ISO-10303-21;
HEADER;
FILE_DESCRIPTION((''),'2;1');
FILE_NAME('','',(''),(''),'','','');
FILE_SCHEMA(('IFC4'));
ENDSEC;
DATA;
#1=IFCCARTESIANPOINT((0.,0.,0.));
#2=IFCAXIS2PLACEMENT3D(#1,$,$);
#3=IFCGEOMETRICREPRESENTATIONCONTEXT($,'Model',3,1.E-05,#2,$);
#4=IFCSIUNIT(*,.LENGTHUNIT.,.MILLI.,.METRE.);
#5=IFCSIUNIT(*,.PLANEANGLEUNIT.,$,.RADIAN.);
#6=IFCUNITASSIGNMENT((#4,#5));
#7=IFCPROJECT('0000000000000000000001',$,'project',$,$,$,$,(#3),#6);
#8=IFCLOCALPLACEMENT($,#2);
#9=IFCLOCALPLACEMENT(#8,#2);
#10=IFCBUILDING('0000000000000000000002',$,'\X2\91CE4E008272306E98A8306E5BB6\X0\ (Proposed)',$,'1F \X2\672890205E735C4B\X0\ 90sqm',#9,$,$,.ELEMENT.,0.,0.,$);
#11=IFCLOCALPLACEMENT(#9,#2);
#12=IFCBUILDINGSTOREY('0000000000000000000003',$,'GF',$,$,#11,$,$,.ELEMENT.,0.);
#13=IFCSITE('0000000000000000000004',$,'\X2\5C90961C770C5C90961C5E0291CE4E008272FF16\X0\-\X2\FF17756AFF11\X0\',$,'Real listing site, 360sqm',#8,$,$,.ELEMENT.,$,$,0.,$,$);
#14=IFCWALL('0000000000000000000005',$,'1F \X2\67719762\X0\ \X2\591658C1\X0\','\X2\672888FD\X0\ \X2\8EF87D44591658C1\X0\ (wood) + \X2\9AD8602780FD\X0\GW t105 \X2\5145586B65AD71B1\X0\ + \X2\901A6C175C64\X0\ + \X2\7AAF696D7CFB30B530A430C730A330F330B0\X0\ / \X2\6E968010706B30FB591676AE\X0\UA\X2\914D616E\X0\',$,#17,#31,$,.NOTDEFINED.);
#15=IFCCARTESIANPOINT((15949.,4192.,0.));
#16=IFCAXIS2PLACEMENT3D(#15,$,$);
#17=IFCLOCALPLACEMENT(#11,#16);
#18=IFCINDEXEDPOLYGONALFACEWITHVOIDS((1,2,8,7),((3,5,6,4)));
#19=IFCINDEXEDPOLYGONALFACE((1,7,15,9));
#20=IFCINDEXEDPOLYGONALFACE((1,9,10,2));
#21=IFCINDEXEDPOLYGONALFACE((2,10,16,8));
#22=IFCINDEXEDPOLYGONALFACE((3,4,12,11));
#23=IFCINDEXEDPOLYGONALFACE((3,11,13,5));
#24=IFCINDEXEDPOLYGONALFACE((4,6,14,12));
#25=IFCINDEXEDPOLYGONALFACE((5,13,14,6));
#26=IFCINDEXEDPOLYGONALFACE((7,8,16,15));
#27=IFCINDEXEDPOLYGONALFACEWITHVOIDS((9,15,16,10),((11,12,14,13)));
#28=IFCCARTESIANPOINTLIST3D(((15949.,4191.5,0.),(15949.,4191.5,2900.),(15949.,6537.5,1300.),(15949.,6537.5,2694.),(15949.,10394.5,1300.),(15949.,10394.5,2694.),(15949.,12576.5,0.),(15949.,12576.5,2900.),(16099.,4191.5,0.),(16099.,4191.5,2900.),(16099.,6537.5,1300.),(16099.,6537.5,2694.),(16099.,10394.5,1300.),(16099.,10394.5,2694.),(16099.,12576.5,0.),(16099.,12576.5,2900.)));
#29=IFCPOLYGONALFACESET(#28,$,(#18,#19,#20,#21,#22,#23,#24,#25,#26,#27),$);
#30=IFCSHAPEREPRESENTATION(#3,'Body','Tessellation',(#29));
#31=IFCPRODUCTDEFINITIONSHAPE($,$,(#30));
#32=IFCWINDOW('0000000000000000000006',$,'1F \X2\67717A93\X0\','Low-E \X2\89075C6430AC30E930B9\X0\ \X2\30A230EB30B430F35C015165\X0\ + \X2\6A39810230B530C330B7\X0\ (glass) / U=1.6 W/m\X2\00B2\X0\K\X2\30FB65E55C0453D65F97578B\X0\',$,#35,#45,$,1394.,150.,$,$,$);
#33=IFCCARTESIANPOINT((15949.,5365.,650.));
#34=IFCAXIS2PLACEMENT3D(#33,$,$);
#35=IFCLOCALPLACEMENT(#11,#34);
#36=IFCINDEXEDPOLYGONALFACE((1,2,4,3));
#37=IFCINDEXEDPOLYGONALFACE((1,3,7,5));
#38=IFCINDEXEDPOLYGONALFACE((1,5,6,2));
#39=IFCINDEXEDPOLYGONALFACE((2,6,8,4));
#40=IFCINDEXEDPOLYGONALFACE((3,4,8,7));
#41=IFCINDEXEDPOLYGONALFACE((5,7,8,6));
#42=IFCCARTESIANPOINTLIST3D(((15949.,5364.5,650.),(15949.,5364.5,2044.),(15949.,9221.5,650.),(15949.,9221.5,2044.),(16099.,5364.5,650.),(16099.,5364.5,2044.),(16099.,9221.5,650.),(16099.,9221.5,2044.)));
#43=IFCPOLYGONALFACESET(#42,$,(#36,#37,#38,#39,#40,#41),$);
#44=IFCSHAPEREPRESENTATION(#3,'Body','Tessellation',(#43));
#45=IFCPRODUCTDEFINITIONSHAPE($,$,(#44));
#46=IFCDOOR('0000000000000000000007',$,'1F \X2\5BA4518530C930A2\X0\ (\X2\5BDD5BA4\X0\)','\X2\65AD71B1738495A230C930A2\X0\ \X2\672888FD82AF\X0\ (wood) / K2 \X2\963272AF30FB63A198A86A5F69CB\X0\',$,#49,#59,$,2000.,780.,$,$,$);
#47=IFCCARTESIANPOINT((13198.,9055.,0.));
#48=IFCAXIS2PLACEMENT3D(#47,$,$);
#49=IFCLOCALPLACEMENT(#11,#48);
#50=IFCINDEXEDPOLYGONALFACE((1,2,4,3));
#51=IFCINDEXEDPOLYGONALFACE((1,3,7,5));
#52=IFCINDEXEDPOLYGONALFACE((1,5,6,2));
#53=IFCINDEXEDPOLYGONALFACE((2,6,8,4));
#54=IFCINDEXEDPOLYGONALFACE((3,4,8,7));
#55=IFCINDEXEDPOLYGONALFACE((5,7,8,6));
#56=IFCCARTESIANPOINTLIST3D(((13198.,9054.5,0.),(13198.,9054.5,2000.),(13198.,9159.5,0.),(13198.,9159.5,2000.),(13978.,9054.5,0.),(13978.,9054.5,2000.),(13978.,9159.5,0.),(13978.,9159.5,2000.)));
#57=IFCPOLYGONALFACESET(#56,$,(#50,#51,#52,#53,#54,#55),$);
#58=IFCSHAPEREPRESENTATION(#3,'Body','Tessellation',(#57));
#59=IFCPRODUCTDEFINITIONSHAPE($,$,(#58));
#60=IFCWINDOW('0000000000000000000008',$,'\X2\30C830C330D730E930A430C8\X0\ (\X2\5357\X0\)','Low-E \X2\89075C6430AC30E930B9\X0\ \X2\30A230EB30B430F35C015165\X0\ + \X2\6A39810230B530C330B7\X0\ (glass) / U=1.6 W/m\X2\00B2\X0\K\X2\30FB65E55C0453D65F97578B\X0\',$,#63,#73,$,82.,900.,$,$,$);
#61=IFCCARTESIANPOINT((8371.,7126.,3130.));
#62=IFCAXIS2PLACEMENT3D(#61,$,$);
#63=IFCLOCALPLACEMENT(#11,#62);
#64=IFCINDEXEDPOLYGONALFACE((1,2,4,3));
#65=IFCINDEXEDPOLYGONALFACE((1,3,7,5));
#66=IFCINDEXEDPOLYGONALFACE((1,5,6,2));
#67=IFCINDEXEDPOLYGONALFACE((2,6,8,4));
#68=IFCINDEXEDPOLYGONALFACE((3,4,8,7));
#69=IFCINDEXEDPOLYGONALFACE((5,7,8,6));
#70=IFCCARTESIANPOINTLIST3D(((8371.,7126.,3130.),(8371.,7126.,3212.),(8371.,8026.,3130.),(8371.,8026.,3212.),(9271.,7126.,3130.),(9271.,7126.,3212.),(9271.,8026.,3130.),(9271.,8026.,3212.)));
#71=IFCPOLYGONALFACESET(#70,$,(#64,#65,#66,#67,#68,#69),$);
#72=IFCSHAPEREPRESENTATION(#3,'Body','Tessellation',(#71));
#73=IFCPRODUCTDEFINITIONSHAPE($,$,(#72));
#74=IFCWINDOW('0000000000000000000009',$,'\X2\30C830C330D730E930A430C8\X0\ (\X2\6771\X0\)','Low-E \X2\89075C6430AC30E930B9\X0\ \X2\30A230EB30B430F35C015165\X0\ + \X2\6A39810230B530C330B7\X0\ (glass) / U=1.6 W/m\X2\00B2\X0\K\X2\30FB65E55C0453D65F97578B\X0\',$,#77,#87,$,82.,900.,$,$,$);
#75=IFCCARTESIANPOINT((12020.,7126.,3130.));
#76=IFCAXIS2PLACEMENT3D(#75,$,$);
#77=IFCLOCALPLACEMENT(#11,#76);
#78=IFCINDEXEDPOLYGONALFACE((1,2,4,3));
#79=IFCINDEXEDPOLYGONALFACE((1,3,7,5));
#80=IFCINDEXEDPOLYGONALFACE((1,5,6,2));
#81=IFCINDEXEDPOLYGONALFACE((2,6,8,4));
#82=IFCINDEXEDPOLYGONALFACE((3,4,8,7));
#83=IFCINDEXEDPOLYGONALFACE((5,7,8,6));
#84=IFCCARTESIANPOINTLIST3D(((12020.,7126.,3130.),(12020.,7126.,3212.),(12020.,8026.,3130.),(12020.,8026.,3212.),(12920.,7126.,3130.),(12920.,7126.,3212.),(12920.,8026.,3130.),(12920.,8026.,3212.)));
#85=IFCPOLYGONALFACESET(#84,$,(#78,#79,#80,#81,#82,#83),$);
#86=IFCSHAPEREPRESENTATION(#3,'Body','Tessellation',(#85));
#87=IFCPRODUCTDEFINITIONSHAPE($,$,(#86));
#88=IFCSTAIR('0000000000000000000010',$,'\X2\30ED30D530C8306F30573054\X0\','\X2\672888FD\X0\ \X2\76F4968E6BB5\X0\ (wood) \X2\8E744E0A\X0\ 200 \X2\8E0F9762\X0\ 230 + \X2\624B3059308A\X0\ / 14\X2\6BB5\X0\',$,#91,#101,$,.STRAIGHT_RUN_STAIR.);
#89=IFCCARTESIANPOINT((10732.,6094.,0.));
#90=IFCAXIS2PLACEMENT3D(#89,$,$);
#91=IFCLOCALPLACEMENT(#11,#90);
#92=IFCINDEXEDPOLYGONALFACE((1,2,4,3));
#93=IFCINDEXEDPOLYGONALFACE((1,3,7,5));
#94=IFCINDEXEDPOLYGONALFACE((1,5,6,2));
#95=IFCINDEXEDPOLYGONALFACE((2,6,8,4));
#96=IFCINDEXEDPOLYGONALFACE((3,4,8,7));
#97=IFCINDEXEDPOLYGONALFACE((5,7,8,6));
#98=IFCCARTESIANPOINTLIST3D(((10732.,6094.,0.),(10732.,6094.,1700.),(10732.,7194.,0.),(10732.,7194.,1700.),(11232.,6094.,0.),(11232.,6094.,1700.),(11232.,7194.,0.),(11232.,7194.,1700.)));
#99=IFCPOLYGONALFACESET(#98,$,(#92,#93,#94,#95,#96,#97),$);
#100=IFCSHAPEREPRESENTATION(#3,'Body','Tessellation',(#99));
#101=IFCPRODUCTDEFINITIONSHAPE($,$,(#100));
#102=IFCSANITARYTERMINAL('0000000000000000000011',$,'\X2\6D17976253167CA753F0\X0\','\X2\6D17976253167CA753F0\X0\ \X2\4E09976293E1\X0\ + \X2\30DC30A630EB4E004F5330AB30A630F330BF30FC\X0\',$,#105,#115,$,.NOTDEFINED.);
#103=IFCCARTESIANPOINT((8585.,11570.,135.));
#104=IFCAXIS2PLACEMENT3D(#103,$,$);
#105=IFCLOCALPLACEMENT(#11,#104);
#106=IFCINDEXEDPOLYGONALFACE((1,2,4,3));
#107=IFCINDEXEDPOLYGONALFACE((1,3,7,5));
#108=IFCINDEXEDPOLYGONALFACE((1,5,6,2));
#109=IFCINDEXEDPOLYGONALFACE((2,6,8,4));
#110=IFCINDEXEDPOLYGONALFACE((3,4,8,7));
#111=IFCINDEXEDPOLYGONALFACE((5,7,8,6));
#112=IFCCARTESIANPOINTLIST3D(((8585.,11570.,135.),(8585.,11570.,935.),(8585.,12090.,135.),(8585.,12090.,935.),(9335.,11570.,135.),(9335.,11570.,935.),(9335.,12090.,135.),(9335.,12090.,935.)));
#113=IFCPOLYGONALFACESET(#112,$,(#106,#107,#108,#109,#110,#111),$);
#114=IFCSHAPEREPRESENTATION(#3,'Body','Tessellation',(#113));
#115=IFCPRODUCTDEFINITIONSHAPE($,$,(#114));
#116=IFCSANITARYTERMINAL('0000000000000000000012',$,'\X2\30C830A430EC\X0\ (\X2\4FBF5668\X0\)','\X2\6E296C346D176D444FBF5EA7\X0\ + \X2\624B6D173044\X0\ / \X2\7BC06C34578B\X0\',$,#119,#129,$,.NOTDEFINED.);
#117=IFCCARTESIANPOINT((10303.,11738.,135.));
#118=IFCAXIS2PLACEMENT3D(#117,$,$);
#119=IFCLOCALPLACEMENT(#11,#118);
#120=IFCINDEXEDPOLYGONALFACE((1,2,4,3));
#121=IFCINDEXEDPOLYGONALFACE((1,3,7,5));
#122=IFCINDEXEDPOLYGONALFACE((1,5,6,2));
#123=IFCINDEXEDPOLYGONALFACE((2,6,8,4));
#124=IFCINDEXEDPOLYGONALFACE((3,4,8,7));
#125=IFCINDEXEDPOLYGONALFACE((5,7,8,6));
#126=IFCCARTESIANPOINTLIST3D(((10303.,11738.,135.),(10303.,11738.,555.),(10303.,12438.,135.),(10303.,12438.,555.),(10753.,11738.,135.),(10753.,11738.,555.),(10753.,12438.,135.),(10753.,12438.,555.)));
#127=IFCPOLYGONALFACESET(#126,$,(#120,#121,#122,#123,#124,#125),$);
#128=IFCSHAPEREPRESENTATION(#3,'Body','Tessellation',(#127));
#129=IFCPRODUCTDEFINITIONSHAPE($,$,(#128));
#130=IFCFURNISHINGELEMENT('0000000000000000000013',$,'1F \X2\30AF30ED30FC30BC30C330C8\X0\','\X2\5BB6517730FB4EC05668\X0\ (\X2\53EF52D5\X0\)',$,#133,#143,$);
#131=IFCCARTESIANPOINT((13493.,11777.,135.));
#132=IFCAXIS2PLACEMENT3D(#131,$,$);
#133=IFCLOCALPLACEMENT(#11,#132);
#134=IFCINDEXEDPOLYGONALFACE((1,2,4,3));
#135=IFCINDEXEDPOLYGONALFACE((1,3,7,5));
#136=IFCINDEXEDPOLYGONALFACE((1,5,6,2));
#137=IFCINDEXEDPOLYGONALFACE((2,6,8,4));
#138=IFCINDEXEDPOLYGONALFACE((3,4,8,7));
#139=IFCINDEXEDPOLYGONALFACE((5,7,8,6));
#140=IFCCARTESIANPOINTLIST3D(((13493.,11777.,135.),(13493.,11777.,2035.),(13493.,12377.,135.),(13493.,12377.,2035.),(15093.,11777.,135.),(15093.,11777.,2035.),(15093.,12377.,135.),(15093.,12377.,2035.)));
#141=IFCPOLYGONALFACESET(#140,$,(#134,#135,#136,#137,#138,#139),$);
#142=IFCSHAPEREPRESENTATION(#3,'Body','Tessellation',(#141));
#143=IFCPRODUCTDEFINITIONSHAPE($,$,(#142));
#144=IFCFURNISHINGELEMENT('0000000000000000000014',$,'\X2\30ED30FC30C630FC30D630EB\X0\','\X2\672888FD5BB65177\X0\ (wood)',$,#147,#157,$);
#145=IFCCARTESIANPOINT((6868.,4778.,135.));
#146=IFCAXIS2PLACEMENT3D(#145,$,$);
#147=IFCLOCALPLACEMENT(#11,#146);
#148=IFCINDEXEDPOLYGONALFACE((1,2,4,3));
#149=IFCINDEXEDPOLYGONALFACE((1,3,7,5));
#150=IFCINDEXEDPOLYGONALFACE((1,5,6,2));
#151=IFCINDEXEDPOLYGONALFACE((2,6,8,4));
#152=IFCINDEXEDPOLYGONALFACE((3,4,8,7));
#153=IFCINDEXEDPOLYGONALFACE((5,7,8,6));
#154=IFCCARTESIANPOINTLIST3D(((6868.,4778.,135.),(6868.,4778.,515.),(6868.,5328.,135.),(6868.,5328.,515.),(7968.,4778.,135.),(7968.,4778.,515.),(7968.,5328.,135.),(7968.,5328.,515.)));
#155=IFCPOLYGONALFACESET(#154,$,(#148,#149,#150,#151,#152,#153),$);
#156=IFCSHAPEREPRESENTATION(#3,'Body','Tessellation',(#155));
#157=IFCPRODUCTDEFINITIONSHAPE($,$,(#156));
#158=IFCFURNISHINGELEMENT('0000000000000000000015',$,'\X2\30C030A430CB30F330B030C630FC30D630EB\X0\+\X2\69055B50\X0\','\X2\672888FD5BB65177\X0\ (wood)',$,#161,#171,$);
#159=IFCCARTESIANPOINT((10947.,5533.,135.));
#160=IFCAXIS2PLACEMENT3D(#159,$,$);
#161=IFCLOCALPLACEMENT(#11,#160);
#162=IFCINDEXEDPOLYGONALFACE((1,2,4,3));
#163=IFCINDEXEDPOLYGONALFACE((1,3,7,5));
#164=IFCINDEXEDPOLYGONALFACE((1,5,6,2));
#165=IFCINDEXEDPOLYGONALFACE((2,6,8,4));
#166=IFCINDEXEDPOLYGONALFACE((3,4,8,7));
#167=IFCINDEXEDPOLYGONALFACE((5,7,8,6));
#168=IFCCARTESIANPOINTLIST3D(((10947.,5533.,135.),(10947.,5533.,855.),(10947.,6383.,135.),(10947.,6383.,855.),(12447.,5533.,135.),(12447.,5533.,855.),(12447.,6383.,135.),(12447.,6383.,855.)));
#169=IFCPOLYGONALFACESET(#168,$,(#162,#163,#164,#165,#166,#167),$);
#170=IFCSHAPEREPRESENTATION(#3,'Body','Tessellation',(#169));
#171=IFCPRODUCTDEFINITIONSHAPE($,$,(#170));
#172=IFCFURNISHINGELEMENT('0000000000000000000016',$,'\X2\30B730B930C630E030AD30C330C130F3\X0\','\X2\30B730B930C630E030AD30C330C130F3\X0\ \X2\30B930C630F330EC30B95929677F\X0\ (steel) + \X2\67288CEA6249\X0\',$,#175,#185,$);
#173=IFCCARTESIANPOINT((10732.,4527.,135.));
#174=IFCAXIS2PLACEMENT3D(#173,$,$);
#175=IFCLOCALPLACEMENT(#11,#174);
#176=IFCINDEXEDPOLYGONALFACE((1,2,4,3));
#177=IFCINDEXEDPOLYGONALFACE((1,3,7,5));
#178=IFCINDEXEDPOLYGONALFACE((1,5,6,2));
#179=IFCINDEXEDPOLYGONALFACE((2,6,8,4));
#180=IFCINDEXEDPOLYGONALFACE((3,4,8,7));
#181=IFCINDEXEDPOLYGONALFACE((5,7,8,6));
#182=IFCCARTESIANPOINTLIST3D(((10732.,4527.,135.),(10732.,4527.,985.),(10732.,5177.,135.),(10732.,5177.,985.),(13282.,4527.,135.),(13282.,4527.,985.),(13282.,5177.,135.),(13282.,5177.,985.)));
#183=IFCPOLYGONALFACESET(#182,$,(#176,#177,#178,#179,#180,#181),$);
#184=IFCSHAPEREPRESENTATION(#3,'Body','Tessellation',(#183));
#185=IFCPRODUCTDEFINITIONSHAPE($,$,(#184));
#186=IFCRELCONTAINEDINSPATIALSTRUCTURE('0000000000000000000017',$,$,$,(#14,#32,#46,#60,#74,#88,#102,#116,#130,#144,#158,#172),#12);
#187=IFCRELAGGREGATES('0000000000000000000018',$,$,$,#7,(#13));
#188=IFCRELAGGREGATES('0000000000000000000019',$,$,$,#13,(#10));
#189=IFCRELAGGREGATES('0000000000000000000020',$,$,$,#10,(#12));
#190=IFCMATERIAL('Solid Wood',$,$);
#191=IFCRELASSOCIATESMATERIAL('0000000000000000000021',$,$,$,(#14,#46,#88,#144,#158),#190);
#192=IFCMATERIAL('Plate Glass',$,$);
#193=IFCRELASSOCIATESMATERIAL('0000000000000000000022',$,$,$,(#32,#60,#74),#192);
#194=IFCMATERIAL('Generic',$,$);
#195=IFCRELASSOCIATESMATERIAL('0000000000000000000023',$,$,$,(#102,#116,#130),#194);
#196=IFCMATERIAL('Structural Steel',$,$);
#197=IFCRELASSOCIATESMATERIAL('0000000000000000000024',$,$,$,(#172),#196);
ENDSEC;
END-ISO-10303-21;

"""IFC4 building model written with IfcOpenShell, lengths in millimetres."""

from ifc_helpers import new_model, si_unit, frame, frame_2d, origin, place, context, project, spatial, rectangle, extrude, material, element, fill, save


model = new_model("IFC4")

# Units and contexts
model_context = context("Model", 3, precision=1e-05, world=origin())
ifc_project = project(units=[si_unit("LENGTHUNIT", "METRE", prefix="MILLI"), si_unit("PLANEANGLEUNIT", "RADIAN")], contexts=[model_context])

# Site, building, storey
site_placement = place(None, origin())
site = spatial("IfcSite", under=ifc_project, at=site_placement, Name="岐阜県岐阜市野一色６-７番１", ObjectType="Real listing site, 360sqm", CompositionType="ELEMENT", RefElevation=0.0)
building_placement = place(site_placement, origin())
building = spatial("IfcBuilding", under=site, at=building_placement, Name="野一色の風の家 (Proposed)", ObjectType="1F 木造平屋 90sqm", CompositionType="ELEMENT", ElevationOfRefHeight=0.0, ElevationOfTerrain=0.0)
storey_placement = place(building_placement, origin())
storey = spatial("IfcBuildingStorey", under=building, at=storey_placement, Name="GF", CompositionType="ELEMENT", Elevation=0.0)

# Wall, opening, window
ifc_material_1 = material(Name="Solid Wood")
wall_1_placement = place(storey_placement, frame((15949.0, 4192.0, 0.0)))
wall_1 = element("IfcWall", 1, at=wall_1_placement, inside=storey, material=ifc_material_1, Name="1F 東面 外壁", Description="木製 軸組外壁 (wood) + 高性能GW t105 充填断熱 + 通気層 + 窯業系サイディング / 準耐火・外皮UA配慮", PredefinedType="NOTDEFINED", context=model_context, shape_type="SweptSolid", body=[
    extrude(rectangle(XDim=150.0, YDim=8385.0, at=frame_2d((75.0, 4192.0))), frame((15949.0, 4192.0, 0.0)), (0.0, 0.0, 1.0), 2900.0),
])
opening_placement = place(storey_placement, frame((15949.0, 5365.0, 650.0)))
opening = element("IfcOpeningElement", 2, at=opening_placement, cuts=wall_1, PredefinedType="NOTDEFINED", context=model_context, shape_type="SweptSolid", body=[
    extrude(rectangle(XDim=150.0, YDim=3857.0, at=frame_2d((75.0, 1928.0))), frame((15949.0, 5365.0, 650.0)), (0.0, 0.0, 1.0), 1394.0),
])
ifc_material_2 = material(Name="Plate Glass")
window_1_placement = place(storey_placement, frame((15949.0, 5365.0, 650.0)))
window_1 = element("IfcWindow", 3, at=window_1_placement, inside=storey, material=ifc_material_2, Name="1F 東窓", Description="Low-E 複層ガラス アルゴン封入 + 樹脂サッシ (glass) / U=1.6 W/m²K・日射取得型", OverallHeight=1394.0, OverallWidth=150.0, context=model_context, shape_type="SweptSolid", body=[
    extrude(rectangle(XDim=150.0, YDim=3857.0, at=frame_2d((75.0, 1928.0))), frame((15949.0, 5365.0, 650.0)), (0.0, 0.0, 1.0), 1394.0),
])
fill(opening, window_1)

# Door
door_placement = place(storey_placement, frame((13198.0, 9055.0, 0.0)))
element("IfcDoor", 4, at=door_placement, inside=storey, material=ifc_material_1, Name="1F 室内ドア (寝室)", Description="断熱玄関ドア 木製芯 (wood) / K2 防犯・採風機構", OverallHeight=2000.0, OverallWidth=780.0, context=model_context, shape_type="SweptSolid", body=[
    extrude(rectangle(XDim=780.0, YDim=105.0, at=frame_2d((390.0, 52.0))), frame((13198.0, 9055.0, 0.0)), (0.0, 0.0, 1.0), 2000.0),
])

# Windows
window_2_placement = place(storey_placement, frame((8371.0, 7126.0, 3130.0)))
element("IfcWindow", 5, at=window_2_placement, inside=storey, material=ifc_material_2, Name="トップライト (南)", Description="Low-E 複層ガラス アルゴン封入 + 樹脂サッシ (glass) / U=1.6 W/m²K・日射取得型", OverallHeight=82.0, OverallWidth=900.0, context=model_context, shape_type="SweptSolid", body=[
    extrude(rectangle(XDim=900.0, YDim=900.0, at=frame_2d((450.0, 450.0))), frame((8371.0, 7126.0, 3130.0)), (0.0, 0.0, 1.0), 82.0),
])
window_3_placement = place(storey_placement, frame((12020.0, 7126.0, 3130.0)))
element("IfcWindow", 6, at=window_3_placement, inside=storey, material=ifc_material_2, Name="トップライト (東)", Description="Low-E 複層ガラス アルゴン封入 + 樹脂サッシ (glass) / U=1.6 W/m²K・日射取得型", OverallHeight=82.0, OverallWidth=900.0, context=model_context, shape_type="SweptSolid", body=[
    extrude(rectangle(XDim=900.0, YDim=900.0, at=frame_2d((450.0, 450.0))), frame((12020.0, 7126.0, 3130.0)), (0.0, 0.0, 1.0), 82.0),
])

# Stair
stair_placement = place(storey_placement, frame((10732.0, 6094.0, 0.0)))
element("IfcStair", 7, at=stair_placement, inside=storey, material=ifc_material_1, Name="ロフトはしご", Description="木製 直階段 (wood) 蹴上 200 踏面 230 + 手すり / 14段", PredefinedType="STRAIGHT_RUN_STAIR", context=model_context, shape_type="SweptSolid", body=[
    extrude(rectangle(XDim=500.0, YDim=1100.0, at=frame_2d((250.0, 550.0))), frame((10732.0, 6094.0, 0.0)), (0.0, 0.0, 1.0), 1700.0),
])

# Sanitary terminals
ifc_material_3 = material(Name="Generic")
sanitary_terminal_1_placement = place(storey_placement, frame((8585.0, 11570.0, 135.0)))
element("IfcSanitaryTerminal", 8, at=sanitary_terminal_1_placement, inside=storey, material=ifc_material_3, Name="洗面化粧台", Description="洗面化粧台 三面鏡 + ボウル一体カウンター", PredefinedType="NOTDEFINED", context=model_context, shape_type="SweptSolid", body=[
    extrude(rectangle(XDim=750.0, YDim=520.0, at=frame_2d((375.0, 260.0))), frame((8585.0, 11570.0, 135.0)), (0.0, 0.0, 1.0), 800.0),
])
sanitary_terminal_2_placement = place(storey_placement, frame((10303.0, 11738.0, 135.0)))
element("IfcSanitaryTerminal", 9, at=sanitary_terminal_2_placement, inside=storey, material=ifc_material_3, Name="トイレ (便器)", Description="温水洗浄便座 + 手洗い / 節水型", PredefinedType="NOTDEFINED", context=model_context, shape_type="SweptSolid", body=[
    extrude(rectangle(XDim=450.0, YDim=700.0, at=frame_2d((225.0, 350.0))), frame((10303.0, 11738.0, 135.0)), (0.0, 0.0, 1.0), 420.0),
])

# Furnishing elements
furnishing_1_placement = place(storey_placement, frame((13493.0, 11777.0, 135.0)))
element("IfcFurnishingElement", 10, at=furnishing_1_placement, inside=storey, material=ifc_material_3, Name="1F クローゼット", Description="家具・什器 (可動)", context=model_context, shape_type="SweptSolid", body=[
    extrude(rectangle(XDim=1600.0, YDim=600.0, at=frame_2d((800.0, 300.0))), frame((13493.0, 11777.0, 135.0)), (0.0, 0.0, 1.0), 1900.0),
])
furnishing_2_placement = place(storey_placement, frame((6868.0, 4778.0, 135.0)))
element("IfcFurnishingElement", 11, at=furnishing_2_placement, inside=storey, material=ifc_material_1, Name="ローテーブル", Description="木製家具 (wood)", context=model_context, shape_type="SweptSolid", body=[
    extrude(rectangle(XDim=1100.0, YDim=550.0, at=frame_2d((550.0, 275.0))), frame((6868.0, 4778.0, 135.0)), (0.0, 0.0, 1.0), 380.0),
])
furnishing_3_placement = place(storey_placement, frame((10947.0, 5533.0, 135.0)))
element("IfcFurnishingElement", 12, at=furnishing_3_placement, inside=storey, material=ifc_material_1, Name="ダイニングテーブル+椅子", Description="木製家具 (wood)", context=model_context, shape_type="SweptSolid", body=[
    extrude(rectangle(XDim=1500.0, YDim=850.0, at=frame_2d((750.0, 425.0))), frame((10947.0, 5533.0, 135.0)), (0.0, 0.0, 1.0), 720.0),
])
ifc_material_4 = material(Name="Structural Steel")
furnishing_4_placement = place(storey_placement, frame((10732.0, 4527.0, 135.0)))
element("IfcFurnishingElement", 13, at=furnishing_4_placement, inside=storey, material=ifc_material_4, Name="システムキッチン", Description="システムキッチン ステンレス天板 (steel) + 木質扉", context=model_context, shape_type="SweptSolid", body=[
    extrude(rectangle(XDim=2550.0, YDim=650.0, at=frame_2d((1275.0, 325.0))), frame((10732.0, 4527.0, 135.0)), (0.0, 0.0, 1.0), 850.0),
])

save(model, "model.ifc")
